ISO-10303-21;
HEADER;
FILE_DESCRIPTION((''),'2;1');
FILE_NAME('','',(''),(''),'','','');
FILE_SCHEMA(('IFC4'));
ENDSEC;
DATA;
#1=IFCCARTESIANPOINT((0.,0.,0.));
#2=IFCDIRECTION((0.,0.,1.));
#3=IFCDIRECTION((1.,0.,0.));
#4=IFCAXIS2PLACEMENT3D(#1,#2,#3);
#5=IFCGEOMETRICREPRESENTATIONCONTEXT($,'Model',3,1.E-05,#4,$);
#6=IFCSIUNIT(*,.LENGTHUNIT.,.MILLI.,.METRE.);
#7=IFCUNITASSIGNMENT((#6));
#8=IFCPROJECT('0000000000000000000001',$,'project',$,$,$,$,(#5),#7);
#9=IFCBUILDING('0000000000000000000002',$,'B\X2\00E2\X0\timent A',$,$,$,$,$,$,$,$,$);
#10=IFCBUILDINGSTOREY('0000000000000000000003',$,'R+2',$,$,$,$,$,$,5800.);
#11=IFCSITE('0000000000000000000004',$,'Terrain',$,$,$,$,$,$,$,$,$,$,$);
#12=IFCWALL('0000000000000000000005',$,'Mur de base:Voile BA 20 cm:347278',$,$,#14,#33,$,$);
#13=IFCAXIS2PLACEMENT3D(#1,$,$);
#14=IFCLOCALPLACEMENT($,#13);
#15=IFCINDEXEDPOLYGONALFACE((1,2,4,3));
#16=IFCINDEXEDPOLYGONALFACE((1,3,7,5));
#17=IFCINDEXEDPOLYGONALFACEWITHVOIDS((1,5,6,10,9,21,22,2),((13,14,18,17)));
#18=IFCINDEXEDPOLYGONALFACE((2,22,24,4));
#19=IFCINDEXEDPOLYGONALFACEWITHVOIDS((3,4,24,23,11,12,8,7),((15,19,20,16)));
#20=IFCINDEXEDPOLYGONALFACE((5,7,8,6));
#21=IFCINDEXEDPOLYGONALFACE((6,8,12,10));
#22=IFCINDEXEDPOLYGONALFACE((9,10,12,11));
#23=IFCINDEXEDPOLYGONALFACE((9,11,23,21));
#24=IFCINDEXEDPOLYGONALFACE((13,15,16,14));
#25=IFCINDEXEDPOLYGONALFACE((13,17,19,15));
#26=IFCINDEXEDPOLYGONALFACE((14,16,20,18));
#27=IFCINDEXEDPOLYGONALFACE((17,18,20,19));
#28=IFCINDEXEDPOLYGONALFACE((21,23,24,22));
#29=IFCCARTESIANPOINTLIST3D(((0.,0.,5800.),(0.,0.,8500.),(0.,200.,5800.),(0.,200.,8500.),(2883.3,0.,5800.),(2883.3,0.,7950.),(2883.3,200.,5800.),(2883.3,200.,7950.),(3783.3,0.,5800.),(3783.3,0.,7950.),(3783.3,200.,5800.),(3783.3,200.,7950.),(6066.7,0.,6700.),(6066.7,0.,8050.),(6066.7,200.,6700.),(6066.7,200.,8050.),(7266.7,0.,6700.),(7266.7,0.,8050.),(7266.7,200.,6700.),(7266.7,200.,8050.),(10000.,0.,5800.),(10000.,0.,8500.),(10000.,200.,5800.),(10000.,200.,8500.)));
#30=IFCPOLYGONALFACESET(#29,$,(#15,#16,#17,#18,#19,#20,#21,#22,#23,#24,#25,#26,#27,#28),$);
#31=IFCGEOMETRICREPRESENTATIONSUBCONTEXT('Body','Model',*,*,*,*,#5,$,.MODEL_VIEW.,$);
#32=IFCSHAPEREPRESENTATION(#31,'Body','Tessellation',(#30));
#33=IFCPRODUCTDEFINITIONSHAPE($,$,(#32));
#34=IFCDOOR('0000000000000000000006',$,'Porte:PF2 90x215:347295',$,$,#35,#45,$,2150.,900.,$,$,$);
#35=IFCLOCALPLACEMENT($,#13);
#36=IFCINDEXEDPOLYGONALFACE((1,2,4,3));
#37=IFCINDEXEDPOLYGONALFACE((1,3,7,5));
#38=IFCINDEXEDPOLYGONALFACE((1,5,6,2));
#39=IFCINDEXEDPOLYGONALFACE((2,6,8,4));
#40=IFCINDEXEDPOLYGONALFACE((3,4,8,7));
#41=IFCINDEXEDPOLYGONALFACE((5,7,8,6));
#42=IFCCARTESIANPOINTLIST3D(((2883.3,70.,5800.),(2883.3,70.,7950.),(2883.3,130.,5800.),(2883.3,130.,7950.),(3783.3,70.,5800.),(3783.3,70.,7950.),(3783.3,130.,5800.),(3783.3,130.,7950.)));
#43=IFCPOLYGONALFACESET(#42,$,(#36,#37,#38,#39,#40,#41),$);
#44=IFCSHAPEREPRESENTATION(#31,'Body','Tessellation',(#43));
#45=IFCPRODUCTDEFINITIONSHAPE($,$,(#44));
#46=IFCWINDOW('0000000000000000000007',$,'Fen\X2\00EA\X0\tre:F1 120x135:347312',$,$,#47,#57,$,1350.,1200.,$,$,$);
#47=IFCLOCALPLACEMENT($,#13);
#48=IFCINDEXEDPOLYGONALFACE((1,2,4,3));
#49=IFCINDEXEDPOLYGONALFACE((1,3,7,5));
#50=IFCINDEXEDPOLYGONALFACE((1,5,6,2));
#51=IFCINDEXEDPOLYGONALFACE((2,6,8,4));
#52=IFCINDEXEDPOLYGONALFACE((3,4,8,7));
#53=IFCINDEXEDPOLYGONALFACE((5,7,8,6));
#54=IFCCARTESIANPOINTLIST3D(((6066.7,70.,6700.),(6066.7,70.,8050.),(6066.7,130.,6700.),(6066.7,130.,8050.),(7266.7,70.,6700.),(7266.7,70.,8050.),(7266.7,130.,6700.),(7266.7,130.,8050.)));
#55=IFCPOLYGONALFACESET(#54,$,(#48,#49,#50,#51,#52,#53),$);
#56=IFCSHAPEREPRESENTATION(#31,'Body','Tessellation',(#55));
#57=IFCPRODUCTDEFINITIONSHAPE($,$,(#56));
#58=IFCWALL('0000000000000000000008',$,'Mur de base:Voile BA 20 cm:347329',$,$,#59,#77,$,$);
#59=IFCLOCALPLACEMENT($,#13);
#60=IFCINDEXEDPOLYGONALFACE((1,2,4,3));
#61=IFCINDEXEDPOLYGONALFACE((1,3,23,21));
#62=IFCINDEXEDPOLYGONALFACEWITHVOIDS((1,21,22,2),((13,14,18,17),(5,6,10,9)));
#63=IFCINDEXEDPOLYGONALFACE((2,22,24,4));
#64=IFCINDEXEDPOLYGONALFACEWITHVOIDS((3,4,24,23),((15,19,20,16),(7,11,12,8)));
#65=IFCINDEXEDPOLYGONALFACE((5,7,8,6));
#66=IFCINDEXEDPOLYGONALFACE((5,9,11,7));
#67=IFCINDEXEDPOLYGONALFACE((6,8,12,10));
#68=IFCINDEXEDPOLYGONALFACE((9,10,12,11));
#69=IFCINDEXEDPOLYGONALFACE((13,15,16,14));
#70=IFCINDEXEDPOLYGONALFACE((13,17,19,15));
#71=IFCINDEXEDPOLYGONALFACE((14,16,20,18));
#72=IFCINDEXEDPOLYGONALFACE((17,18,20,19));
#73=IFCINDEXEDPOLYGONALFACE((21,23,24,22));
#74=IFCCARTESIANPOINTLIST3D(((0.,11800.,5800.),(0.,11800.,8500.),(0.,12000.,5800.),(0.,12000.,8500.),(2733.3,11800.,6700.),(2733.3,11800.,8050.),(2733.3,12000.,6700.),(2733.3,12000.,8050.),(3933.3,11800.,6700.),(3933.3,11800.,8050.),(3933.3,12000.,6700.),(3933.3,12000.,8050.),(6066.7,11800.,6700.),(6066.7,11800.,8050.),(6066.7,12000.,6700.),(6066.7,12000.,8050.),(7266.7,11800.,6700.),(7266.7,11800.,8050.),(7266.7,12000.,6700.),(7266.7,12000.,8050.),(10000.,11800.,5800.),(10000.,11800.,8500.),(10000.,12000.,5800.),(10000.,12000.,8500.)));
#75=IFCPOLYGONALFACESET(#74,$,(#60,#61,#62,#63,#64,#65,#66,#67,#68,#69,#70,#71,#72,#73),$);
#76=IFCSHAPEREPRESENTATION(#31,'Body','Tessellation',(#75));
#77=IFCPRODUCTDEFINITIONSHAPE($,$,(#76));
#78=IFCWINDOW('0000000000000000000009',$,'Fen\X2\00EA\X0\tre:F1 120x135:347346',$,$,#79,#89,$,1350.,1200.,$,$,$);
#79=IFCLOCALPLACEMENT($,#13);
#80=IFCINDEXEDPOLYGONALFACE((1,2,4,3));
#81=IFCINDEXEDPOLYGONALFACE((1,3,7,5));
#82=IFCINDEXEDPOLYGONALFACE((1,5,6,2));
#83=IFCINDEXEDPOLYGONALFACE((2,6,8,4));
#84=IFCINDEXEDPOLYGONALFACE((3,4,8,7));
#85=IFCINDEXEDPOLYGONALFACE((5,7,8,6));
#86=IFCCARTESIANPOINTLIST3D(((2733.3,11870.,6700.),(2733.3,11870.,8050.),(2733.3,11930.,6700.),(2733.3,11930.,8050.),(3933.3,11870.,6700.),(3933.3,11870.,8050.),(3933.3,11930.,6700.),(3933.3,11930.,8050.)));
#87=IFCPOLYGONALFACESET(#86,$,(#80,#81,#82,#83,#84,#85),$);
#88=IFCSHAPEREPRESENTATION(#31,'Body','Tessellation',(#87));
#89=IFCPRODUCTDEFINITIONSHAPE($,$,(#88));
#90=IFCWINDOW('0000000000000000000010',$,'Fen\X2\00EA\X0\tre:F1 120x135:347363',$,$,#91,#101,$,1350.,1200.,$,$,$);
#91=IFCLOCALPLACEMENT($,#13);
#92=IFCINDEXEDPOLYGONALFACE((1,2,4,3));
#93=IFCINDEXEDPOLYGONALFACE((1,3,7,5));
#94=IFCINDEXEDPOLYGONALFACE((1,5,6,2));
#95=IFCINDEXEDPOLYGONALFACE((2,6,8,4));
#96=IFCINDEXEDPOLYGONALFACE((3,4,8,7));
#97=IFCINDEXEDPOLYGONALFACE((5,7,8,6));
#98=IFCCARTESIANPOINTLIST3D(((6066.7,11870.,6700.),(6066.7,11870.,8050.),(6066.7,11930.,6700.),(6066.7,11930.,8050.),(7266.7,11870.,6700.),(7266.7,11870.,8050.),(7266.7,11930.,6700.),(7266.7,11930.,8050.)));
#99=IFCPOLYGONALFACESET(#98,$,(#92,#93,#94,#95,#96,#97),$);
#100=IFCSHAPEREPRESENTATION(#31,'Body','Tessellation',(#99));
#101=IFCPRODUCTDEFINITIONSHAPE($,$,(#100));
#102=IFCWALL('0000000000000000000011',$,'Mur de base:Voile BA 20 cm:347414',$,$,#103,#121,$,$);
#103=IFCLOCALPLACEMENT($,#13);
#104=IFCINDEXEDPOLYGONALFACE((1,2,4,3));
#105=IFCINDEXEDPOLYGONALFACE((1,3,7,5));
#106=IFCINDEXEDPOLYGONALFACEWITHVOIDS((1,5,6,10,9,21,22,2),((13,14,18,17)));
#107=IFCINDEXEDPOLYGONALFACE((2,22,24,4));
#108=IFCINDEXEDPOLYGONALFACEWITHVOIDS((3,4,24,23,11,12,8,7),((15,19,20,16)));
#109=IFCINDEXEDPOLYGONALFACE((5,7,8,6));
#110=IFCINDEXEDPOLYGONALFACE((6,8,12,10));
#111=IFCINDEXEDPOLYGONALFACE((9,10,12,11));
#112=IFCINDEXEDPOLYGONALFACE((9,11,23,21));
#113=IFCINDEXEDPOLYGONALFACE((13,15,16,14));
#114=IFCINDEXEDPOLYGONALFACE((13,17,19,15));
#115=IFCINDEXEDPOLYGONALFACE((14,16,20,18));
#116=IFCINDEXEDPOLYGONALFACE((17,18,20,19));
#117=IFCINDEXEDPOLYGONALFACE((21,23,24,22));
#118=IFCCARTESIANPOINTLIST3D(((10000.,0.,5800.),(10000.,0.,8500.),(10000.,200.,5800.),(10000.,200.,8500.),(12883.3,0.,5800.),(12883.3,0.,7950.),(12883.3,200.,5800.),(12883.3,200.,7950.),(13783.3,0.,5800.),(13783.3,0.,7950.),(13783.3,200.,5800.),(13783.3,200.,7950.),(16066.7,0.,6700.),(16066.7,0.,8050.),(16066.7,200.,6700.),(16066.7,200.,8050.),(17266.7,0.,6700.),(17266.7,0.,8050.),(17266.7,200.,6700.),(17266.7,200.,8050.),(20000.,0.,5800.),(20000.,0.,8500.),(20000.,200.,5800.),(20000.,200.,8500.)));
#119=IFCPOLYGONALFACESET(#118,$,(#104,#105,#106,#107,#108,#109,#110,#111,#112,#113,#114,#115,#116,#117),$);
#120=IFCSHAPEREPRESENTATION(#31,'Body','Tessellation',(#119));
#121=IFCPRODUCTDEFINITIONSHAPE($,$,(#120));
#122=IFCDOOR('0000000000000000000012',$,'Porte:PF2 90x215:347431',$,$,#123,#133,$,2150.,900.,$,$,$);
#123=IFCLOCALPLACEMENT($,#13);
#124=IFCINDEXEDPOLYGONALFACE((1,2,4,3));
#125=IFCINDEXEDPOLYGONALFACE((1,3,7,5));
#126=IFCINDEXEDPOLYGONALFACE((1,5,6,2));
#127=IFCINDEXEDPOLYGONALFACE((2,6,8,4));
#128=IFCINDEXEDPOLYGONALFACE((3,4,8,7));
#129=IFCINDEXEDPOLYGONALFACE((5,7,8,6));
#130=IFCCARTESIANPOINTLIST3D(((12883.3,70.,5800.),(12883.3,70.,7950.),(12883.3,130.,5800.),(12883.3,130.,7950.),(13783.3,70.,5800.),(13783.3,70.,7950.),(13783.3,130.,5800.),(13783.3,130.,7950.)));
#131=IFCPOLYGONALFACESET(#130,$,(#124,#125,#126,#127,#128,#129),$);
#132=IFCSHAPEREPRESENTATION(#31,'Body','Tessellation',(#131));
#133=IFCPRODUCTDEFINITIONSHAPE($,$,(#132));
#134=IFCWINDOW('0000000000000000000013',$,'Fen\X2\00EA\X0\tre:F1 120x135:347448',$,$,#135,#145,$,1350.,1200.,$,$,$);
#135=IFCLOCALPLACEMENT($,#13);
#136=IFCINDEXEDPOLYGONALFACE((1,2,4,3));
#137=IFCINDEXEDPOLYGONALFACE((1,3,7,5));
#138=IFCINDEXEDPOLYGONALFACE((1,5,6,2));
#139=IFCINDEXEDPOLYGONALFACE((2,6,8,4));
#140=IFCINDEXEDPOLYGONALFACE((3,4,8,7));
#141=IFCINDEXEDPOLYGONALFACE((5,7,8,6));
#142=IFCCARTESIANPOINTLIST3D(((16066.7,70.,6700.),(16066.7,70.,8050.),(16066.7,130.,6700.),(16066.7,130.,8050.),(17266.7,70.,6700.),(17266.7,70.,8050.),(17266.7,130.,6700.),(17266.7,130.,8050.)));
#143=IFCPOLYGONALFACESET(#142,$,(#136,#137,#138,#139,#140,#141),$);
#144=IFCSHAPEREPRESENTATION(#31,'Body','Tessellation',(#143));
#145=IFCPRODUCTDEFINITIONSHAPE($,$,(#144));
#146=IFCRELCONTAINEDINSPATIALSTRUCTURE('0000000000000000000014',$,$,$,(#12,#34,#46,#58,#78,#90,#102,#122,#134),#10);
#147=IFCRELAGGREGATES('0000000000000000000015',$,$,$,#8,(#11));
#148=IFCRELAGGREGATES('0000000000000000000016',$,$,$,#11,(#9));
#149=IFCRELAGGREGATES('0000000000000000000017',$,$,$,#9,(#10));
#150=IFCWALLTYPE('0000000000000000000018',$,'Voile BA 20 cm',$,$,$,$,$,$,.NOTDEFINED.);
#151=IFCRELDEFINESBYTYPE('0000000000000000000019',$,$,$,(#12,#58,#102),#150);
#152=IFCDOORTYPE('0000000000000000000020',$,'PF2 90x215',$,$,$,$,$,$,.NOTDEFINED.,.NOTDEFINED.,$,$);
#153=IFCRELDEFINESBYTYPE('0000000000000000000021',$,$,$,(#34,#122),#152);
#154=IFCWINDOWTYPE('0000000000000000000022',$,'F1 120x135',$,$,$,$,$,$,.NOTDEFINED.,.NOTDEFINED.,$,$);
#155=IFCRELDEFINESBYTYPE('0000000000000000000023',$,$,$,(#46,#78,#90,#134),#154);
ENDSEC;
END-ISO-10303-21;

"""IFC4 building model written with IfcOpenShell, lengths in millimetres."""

from ifc_helpers import new_model, si_unit, frame, frame_2d, origin_with_axes, place, context, subcontext, project, spatial, rectangle, extrude, type_object, element, fill, save


model = new_model("IFC4")

# Units and contexts
model_context = context("Model", 3, precision=1e-05, world=origin_with_axes())
body_context = subcontext(model_context, "Body", "Model", "MODEL_VIEW")
ifc_project = project(units=[si_unit("LENGTHUNIT", "METRE", prefix="MILLI")], contexts=[model_context])

# Site, building, storey
site = spatial("IfcSite", under=ifc_project, Name="Terrain")
building = spatial("IfcBuilding", under=site, Name="Bâtiment A")
storey = spatial("IfcBuildingStorey", under=building, Name="R+2", Elevation=5800.0)

# Wall, openings, door, window
wall_type_1 = type_object("IfcWallType", Name="Voile BA 20 cm", PredefinedType="NOTDEFINED")
wall_1_placement = place(None, origin_with_axes())
wall_1 = element("IfcWall", 1, at=wall_1_placement, inside=storey, type_object=wall_type_1, Name="Mur de base:Voile BA 20 cm:347278", context=body_context, shape_type="SweptSolid", body=[
    extrude(rectangle(XDim=10000.0, YDim=200.0, at=frame_2d((5000.0, 100.0))), frame((0.0, 0.0, 5800.0), z_axis=(0.0, 0.0, 1.0), x_axis=(1.0, 0.0, 0.0)), (0.0, 0.0, 1.0), 2700.0),
])
opening_1_placement = place(None, origin_with_axes())
opening_1 = element("IfcOpeningElement", 2, at=opening_1_placement, cuts=wall_1, context=body_context, shape_type="SweptSolid", body=[
    extrude(rectangle(XDim=900.0, YDim=320.0, at=frame_2d((3333.3, 100.0))), frame((0.0, 0.0, 5800.0), z_axis=(0.0, 0.0, 1.0), x_axis=(1.0, 0.0, 0.0)), (0.0, 0.0, 1.0), 2150.0),
])
opening_2_placement = place(None, origin_with_axes())
opening_2 = element("IfcOpeningElement", 3, at=opening_2_placement, cuts=wall_1, context=body_context, shape_type="SweptSolid", body=[
    extrude(rectangle(XDim=1200.0, YDim=320.0, at=frame_2d((6666.7, 100.0))), frame((0.0, 0.0, 6700.0), z_axis=(0.0, 0.0, 1.0), x_axis=(1.0, 0.0, 0.0)), (0.0, 0.0, 1.0), 1350.0),
])
door_type = type_object("IfcDoorType", Name="PF2 90x215", OperationType="NOTDEFINED", PredefinedType="NOTDEFINED")
door_1_placement = place(None, origin_with_axes())
door_1 = element("IfcDoor", 4, at=door_1_placement, inside=storey, type_object=door_type, Name="Porte:PF2 90x215:347295", OverallHeight=2150.0, OverallWidth=900.0, context=body_context, shape_type="SweptSolid", body=[
    extrude(rectangle(XDim=900.0, YDim=60.0, at=frame_2d((3333.3, 100.0))), frame((0.0, 0.0, 5800.0), z_axis=(0.0, 0.0, 1.0), x_axis=(1.0, 0.0, 0.0)), (0.0, 0.0, 1.0), 2150.0),
])
fill(opening_1, door_1)
window_type = type_object("IfcWindowType", Name="F1 120x135", PartitioningType="NOTDEFINED", PredefinedType="NOTDEFINED")
window_1_placement = place(None, origin_with_axes())
window_1 = element("IfcWindow", 5, at=window_1_placement, inside=storey, type_object=window_type, Name="Fenêtre:F1 120x135:347312", OverallHeight=1350.0, OverallWidth=1200.0, context=body_context, shape_type="SweptSolid", body=[
    extrude(rectangle(XDim=1200.0, YDim=60.0, at=frame_2d((6666.7, 100.0))), frame((0.0, 0.0, 6700.0), z_axis=(0.0, 0.0, 1.0), x_axis=(1.0, 0.0, 0.0)), (0.0, 0.0, 1.0), 1350.0),
])
fill(opening_2, window_1)

# Wall, openings, windows
wall_2_placement = place(None, origin_with_axes())
wall_2 = element("IfcWall", 6, at=wall_2_placement, inside=storey, type_object=wall_type_1, Name="Mur de base:Voile BA 20 cm:347329", context=body_context, shape_type="SweptSolid", body=[
    extrude(rectangle(XDim=10000.0, YDim=200.0, at=frame_2d((5000.0, 11900.0))), frame((0.0, 0.0, 5800.0), z_axis=(0.0, 0.0, 1.0), x_axis=(1.0, 0.0, 0.0)), (0.0, 0.0, 1.0), 2700.0),
])
opening_3_placement = place(None, origin_with_axes())
opening_3 = element("IfcOpeningElement", 7, at=opening_3_placement, cuts=wall_2, context=body_context, shape_type="SweptSolid", body=[
    extrude(rectangle(XDim=1200.0, YDim=320.0, at=frame_2d((3333.3, 11900.0))), frame((0.0, 0.0, 6700.0), z_axis=(0.0, 0.0, 1.0), x_axis=(1.0, 0.0, 0.0)), (0.0, 0.0, 1.0), 1350.0),
])
opening_4_placement = place(None, origin_with_axes())
opening_4 = element("IfcOpeningElement", 8, at=opening_4_placement, cuts=wall_2, context=body_context, shape_type="SweptSolid", body=[
    extrude(rectangle(XDim=1200.0, YDim=320.0, at=frame_2d((6666.7, 11900.0))), frame((0.0, 0.0, 6700.0), z_axis=(0.0, 0.0, 1.0), x_axis=(1.0, 0.0, 0.0)), (0.0, 0.0, 1.0), 1350.0),
])
window_2_placement = place(None, origin_with_axes())
window_2 = element("IfcWindow", 9, at=window_2_placement, inside=storey, type_object=window_type, Name="Fenêtre:F1 120x135:347346", OverallHeight=1350.0, OverallWidth=1200.0, context=body_context, shape_type="SweptSolid", body=[
    extrude(rectangle(XDim=1200.0, YDim=60.0, at=frame_2d((3333.3, 11900.0))), frame((0.0, 0.0, 6700.0), z_axis=(0.0, 0.0, 1.0), x_axis=(1.0, 0.0, 0.0)), (0.0, 0.0, 1.0), 1350.0),
])
fill(opening_3, window_2)
window_3_placement = place(None, origin_with_axes())
window_3 = element("IfcWindow", 10, at=window_3_placement, inside=storey, type_object=window_type, Name="Fenêtre:F1 120x135:347363", OverallHeight=1350.0, OverallWidth=1200.0, context=body_context, shape_type="SweptSolid", body=[
    extrude(rectangle(XDim=1200.0, YDim=60.0, at=frame_2d((6666.7, 11900.0))), frame((0.0, 0.0, 6700.0), z_axis=(0.0, 0.0, 1.0), x_axis=(1.0, 0.0, 0.0)), (0.0, 0.0, 1.0), 1350.0),
])
fill(opening_4, window_3)

# Wall, openings, door, window
wall_3_placement = place(None, origin_with_axes())
wall_3 = element("IfcWall", 11, at=wall_3_placement, inside=storey, type_object=wall_type_1, Name="Mur de base:Voile BA 20 cm:347414", context=body_context, shape_type="SweptSolid", body=[
    extrude(rectangle(XDim=10000.0, YDim=200.0, at=frame_2d((15000.0, 100.0))), frame((0.0, 0.0, 5800.0), z_axis=(0.0, 0.0, 1.0), x_axis=(1.0, 0.0, 0.0)), (0.0, 0.0, 1.0), 2700.0),
])
opening_5_placement = place(None, origin_with_axes())
opening_5 = element("IfcOpeningElement", 12, at=opening_5_placement, cuts=wall_3, context=body_context, shape_type="SweptSolid", body=[
    extrude(rectangle(XDim=900.0, YDim=320.0, at=frame_2d((13333.3, 100.0))), frame((0.0, 0.0, 5800.0), z_axis=(0.0, 0.0, 1.0), x_axis=(1.0, 0.0, 0.0)), (0.0, 0.0, 1.0), 2150.0),
])
opening_6_placement = place(None, origin_with_axes())
opening_6 = element("IfcOpeningElement", 13, at=opening_6_placement, cuts=wall_3, context=body_context, shape_type="SweptSolid", body=[
    extrude(rectangle(XDim=1200.0, YDim=320.0, at=frame_2d((16666.7, 100.0))), frame((0.0, 0.0, 6700.0), z_axis=(0.0, 0.0, 1.0), x_axis=(1.0, 0.0, 0.0)), (0.0, 0.0, 1.0), 1350.0),
])
door_2_placement = place(None, origin_with_axes())
door_2 = element("IfcDoor", 14, at=door_2_placement, inside=storey, type_object=door_type, Name="Porte:PF2 90x215:347431", OverallHeight=2150.0, OverallWidth=900.0, context=body_context, shape_type="SweptSolid", body=[
    extrude(rectangle(XDim=900.0, YDim=60.0, at=frame_2d((13333.3, 100.0))), frame((0.0, 0.0, 5800.0), z_axis=(0.0, 0.0, 1.0), x_axis=(1.0, 0.0, 0.0)), (0.0, 0.0, 1.0), 2150.0),
])
fill(opening_5, door_2)
window_4_placement = place(None, origin_with_axes())
window_4 = element("IfcWindow", 15, at=window_4_placement, inside=storey, type_object=window_type, Name="Fenêtre:F1 120x135:347448", OverallHeight=1350.0, OverallWidth=1200.0, context=body_context, shape_type="SweptSolid", body=[
    extrude(rectangle(XDim=1200.0, YDim=60.0, at=frame_2d((16666.7, 100.0))), frame((0.0, 0.0, 6700.0), z_axis=(0.0, 0.0, 1.0), x_axis=(1.0, 0.0, 0.0)), (0.0, 0.0, 1.0), 1350.0),
])
fill(opening_6, window_4)

save(model, "model.ifc")
